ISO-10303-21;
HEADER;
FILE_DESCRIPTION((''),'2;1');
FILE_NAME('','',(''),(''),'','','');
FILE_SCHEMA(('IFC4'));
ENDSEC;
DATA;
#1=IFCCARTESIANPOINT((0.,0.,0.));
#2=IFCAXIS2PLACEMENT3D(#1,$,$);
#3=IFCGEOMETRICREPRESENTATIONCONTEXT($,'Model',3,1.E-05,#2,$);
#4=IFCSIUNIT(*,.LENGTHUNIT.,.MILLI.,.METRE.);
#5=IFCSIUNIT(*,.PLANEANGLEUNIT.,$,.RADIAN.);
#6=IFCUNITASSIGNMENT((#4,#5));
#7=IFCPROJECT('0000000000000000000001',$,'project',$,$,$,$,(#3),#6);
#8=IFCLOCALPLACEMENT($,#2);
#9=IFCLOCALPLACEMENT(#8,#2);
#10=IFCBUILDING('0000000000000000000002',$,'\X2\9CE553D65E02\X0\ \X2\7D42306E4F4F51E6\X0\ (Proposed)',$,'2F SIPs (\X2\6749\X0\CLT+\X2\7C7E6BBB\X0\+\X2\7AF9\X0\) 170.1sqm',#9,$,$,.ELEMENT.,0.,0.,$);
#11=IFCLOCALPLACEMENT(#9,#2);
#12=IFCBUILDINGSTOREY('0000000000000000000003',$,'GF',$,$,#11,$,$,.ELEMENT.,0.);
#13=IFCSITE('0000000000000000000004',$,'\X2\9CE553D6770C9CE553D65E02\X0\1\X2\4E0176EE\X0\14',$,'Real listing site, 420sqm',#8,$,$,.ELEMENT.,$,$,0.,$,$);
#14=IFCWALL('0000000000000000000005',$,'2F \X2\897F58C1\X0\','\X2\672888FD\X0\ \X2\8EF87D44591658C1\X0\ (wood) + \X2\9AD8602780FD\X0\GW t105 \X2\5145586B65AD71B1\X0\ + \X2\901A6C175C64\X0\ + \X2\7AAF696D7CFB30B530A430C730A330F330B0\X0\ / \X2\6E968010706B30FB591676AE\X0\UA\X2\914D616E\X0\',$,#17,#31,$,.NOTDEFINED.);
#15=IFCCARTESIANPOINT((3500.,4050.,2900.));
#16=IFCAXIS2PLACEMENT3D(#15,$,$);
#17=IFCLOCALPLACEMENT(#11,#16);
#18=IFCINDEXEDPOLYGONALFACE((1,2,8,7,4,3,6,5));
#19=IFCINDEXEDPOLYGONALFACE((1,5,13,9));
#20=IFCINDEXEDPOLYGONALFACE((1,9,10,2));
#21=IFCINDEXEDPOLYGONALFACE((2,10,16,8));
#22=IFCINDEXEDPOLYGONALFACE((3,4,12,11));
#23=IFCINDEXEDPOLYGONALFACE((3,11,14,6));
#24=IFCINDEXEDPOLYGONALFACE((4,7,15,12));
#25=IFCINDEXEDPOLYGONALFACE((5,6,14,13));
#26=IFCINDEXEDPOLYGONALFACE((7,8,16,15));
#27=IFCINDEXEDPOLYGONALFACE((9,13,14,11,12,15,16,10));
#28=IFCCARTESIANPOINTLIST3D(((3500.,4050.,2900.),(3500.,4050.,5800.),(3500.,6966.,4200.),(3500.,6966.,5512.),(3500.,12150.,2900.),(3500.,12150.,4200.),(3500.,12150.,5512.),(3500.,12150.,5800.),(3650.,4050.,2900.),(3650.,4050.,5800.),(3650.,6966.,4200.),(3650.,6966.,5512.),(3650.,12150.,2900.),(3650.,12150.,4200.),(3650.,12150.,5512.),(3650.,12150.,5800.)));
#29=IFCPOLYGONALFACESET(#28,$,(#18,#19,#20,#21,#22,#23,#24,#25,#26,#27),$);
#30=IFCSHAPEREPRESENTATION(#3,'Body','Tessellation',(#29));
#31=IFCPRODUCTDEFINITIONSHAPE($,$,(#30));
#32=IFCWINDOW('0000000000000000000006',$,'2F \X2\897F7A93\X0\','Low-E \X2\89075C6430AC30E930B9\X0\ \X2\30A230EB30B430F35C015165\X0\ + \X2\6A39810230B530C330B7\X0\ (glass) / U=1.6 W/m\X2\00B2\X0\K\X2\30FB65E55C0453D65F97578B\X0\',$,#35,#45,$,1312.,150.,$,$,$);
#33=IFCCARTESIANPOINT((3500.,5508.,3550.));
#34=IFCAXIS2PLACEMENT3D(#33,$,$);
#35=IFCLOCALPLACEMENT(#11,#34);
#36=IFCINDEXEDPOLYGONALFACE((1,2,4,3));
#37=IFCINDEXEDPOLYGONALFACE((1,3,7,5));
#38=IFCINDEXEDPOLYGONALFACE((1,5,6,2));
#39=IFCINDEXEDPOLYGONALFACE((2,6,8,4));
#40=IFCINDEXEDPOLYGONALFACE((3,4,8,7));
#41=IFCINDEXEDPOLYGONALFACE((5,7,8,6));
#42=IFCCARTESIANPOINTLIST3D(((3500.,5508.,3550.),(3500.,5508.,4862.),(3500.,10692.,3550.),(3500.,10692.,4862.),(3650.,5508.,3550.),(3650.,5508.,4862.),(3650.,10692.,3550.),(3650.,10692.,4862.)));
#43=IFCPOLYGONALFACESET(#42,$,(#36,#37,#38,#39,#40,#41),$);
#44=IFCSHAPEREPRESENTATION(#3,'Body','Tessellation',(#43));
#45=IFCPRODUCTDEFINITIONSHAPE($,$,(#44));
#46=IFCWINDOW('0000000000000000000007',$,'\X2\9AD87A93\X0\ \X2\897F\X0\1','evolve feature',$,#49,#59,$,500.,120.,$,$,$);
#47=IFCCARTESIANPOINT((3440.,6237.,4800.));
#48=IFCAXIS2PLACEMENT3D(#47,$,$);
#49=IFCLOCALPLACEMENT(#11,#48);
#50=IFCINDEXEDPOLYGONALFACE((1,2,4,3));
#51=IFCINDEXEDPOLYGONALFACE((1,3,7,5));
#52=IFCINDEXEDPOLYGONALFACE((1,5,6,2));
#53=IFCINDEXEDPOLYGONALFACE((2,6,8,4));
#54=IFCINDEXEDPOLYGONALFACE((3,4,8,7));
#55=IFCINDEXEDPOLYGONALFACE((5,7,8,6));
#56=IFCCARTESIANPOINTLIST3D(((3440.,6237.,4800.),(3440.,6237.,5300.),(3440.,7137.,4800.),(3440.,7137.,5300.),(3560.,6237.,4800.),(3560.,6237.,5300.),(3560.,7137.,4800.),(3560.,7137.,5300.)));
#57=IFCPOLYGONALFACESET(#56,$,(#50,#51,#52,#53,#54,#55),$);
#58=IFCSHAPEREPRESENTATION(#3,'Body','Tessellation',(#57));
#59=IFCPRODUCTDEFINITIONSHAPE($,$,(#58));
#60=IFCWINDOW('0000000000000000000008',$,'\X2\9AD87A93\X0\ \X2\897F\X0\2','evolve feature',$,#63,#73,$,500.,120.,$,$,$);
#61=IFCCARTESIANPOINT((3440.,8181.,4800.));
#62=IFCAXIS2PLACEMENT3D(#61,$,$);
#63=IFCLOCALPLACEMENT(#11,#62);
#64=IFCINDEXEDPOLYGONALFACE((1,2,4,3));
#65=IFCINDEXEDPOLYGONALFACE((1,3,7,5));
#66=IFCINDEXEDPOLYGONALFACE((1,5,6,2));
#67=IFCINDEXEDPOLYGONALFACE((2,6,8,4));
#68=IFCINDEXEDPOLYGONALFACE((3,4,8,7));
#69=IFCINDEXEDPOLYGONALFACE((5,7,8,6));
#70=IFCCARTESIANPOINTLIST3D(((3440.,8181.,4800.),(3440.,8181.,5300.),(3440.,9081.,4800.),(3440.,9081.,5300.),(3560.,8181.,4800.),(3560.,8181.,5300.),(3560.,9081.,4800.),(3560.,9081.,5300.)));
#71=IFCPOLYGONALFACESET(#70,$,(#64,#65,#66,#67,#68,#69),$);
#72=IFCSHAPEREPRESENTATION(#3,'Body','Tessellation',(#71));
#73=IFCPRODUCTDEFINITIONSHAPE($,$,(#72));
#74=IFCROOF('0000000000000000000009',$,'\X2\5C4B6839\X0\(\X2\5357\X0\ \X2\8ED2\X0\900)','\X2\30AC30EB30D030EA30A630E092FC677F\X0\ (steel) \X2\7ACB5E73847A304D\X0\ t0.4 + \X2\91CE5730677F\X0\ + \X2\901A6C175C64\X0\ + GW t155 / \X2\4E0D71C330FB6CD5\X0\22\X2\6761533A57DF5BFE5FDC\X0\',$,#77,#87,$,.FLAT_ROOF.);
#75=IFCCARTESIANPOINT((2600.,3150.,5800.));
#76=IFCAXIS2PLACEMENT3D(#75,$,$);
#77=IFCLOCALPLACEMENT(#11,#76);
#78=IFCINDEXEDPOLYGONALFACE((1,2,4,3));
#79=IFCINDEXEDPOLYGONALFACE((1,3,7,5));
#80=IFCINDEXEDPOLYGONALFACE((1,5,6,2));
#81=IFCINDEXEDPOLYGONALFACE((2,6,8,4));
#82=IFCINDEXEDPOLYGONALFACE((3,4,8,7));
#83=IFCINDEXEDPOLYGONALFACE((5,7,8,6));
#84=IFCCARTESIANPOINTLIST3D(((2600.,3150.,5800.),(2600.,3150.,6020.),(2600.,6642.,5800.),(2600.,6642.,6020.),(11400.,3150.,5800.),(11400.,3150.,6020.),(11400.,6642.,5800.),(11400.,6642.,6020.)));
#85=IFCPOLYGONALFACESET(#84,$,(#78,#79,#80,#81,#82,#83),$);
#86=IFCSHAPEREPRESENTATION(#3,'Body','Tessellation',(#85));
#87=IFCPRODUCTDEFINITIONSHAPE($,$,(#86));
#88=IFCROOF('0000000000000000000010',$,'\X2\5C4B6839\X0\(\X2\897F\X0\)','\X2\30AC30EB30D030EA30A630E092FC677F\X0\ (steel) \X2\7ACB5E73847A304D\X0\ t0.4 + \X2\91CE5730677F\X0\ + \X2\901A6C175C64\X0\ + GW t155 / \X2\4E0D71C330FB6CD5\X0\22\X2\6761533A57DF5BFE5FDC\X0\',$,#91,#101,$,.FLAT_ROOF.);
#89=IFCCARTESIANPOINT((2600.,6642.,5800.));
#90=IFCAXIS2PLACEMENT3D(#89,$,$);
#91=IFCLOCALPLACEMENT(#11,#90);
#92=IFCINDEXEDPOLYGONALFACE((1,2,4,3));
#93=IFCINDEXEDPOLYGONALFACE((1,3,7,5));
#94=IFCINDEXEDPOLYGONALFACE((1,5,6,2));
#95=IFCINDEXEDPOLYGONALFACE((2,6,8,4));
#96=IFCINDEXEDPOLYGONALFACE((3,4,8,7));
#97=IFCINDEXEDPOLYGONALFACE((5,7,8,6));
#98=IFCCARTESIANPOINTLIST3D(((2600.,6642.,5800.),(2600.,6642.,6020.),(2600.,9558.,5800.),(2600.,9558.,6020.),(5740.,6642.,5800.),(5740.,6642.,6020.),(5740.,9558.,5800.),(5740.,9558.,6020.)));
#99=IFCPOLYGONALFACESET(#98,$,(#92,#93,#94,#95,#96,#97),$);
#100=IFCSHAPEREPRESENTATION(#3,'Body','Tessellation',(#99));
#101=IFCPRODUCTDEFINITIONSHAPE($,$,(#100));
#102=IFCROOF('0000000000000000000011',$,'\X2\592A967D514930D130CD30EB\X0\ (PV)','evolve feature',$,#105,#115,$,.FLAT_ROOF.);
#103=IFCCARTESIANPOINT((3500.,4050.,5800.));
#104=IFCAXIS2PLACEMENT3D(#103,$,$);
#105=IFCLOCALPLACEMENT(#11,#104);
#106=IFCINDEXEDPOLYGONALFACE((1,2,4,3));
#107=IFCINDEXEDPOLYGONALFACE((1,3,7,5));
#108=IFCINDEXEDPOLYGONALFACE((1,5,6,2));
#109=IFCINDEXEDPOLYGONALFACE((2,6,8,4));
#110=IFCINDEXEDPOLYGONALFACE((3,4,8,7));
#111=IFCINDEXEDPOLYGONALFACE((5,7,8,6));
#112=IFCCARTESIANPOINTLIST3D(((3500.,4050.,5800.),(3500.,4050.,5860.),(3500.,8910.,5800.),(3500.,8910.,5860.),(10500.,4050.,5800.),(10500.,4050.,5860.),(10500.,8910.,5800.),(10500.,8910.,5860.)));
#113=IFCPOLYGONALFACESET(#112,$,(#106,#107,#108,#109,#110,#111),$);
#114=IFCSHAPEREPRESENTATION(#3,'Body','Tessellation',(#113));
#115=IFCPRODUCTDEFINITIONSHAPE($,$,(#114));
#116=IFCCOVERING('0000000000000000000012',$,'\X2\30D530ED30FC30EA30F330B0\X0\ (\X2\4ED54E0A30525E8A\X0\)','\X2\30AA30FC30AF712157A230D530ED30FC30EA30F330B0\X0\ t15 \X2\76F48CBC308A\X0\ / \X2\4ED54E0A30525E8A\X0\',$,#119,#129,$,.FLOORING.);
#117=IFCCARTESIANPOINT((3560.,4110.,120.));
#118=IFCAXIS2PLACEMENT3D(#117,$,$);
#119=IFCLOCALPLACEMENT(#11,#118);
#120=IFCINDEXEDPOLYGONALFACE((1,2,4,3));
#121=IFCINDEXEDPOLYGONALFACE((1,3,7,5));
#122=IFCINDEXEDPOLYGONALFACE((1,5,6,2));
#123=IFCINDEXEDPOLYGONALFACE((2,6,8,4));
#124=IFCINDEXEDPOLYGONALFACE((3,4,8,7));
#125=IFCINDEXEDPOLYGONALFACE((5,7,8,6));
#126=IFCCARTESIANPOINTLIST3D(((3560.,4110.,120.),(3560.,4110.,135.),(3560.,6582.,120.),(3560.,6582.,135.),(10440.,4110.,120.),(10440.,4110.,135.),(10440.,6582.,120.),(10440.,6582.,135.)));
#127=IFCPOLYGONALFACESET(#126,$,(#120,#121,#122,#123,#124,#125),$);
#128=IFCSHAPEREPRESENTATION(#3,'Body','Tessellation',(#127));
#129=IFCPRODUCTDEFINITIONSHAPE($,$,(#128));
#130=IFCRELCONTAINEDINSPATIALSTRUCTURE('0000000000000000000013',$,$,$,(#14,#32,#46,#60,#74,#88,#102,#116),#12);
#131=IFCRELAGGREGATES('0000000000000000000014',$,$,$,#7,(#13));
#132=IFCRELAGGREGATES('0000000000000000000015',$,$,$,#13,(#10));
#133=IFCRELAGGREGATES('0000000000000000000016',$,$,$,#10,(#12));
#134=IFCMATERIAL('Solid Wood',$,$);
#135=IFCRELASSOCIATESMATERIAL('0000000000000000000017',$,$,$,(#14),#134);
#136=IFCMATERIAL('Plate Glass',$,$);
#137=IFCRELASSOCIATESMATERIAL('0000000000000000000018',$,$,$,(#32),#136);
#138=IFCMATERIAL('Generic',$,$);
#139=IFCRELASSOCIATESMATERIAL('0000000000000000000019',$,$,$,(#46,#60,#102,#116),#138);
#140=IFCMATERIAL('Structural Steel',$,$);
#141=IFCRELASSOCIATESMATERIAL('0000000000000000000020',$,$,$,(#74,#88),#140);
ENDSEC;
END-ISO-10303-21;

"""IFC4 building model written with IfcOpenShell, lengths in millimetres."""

from ifc_helpers import new_model, si_unit, frame, frame_2d, origin, place, context, project, spatial, rectangle, extrude, material, element, fill, save


model = new_model("IFC4")

# Units and contexts
model_context = context("Model", 3, precision=1e-05, world=origin())
ifc_project = project(units=[si_unit("LENGTHUNIT", "METRE", prefix="MILLI"), si_unit("PLANEANGLEUNIT", "RADIAN")], contexts=[model_context])

# Site, building, storey
site_placement = place(None, origin())
site = spatial("IfcSite", under=ifc_project, at=site_placement, Name="鳥取県鳥取市1丁目14", ObjectType="Real listing site, 420sqm", CompositionType="ELEMENT", RefElevation=0.0)
building_placement = place(site_placement, origin())
building = spatial("IfcBuilding", under=site, at=building_placement, Name="鳥取市 終の住処 (Proposed)", ObjectType="2F SIPs (杉CLT+籾殻+竹) 170.1sqm", CompositionType="ELEMENT", ElevationOfRefHeight=0.0, ElevationOfTerrain=0.0)
storey_placement = place(building_placement, origin())
storey = spatial("IfcBuildingStorey", under=building, at=storey_placement, Name="GF", CompositionType="ELEMENT", Elevation=0.0)

# Shared definitions
ifc_material_1 = material(Name="Solid Wood")
ifc_material_2 = material(Name="Generic")

# Shared definitions
ifc_material_3 = material(Name="Plate Glass")

# Wall, openings, windows
wall_1_placement = place(storey_placement, frame((3500.0, 4050.0, 2900.0)))
wall_1 = element("IfcWall", 1, at=wall_1_placement, inside=storey, material=ifc_material_1, Name="2F 西壁", Description="木製 軸組外壁 (wood) + 高性能GW t105 充填断熱 + 通気層 + 窯業系サイディング / 準耐火・外皮UA配慮", PredefinedType="NOTDEFINED", context=model_context, shape_type="SweptSolid", body=[
    extrude(rectangle(XDim=150.0, YDim=8100.0, at=frame_2d((75.0, 4050.0))), frame((3500.0, 4050.0, 2900.0)), (0.0, 0.0, 1.0), 2900.0),
])
opening_1_placement = place(storey_placement, frame((3500.0, 5508.0, 3550.0)))
opening_1 = element("IfcOpeningElement", 2, at=opening_1_placement, cuts=wall_1, PredefinedType="NOTDEFINED", context=model_context, shape_type="SweptSolid", body=[
    extrude(rectangle(XDim=150.0, YDim=5184.0, at=frame_2d((75.0, 2592.0))), frame((3500.0, 5508.0, 3550.0)), (0.0, 0.0, 1.0), 1312.0),
])
opening_2_placement = place(storey_placement, frame((3440.0, 6237.0, 4800.0)))
opening_2 = element("IfcOpeningElement", 3, at=opening_2_placement, cuts=wall_1, PredefinedType="NOTDEFINED", context=model_context, shape_type="SweptSolid", body=[
    extrude(rectangle(XDim=120.0, YDim=900.0, at=frame_2d((60.0, 450.0))), frame((3440.0, 6237.0, 4800.0)), (0.0, 0.0, 1.0), 500.0),
])
opening_3_placement = place(storey_placement, frame((3440.0, 8181.0, 4800.0)))
opening_3 = element("IfcOpeningElement", 4, at=opening_3_placement, cuts=wall_1, PredefinedType="NOTDEFINED", context=model_context, shape_type="SweptSolid", body=[
    extrude(rectangle(XDim=120.0, YDim=900.0, at=frame_2d((60.0, 450.0))), frame((3440.0, 8181.0, 4800.0)), (0.0, 0.0, 1.0), 500.0),
])
window_1_placement = place(storey_placement, frame((3500.0, 5508.0, 3550.0)))
window_1 = element("IfcWindow", 5, at=window_1_placement, inside=storey, material=ifc_material_3, Name="2F 西窓", Description="Low-E 複層ガラス アルゴン封入 + 樹脂サッシ (glass) / U=1.6 W/m²K・日射取得型", OverallHeight=1312.0, OverallWidth=150.0, context=model_context, shape_type="SweptSolid", body=[
    extrude(rectangle(XDim=150.0, YDim=5184.0, at=frame_2d((75.0, 2592.0))), frame((3500.0, 5508.0, 3550.0)), (0.0, 0.0, 1.0), 1312.0),
])
fill(opening_1, window_1)
window_2_placement = place(storey_placement, frame((3440.0, 6237.0, 4800.0)))
window_2 = element("IfcWindow", 6, at=window_2_placement, inside=storey, material=ifc_material_2, Name="高窓 西1", Description="evolve feature", OverallHeight=500.0, OverallWidth=120.0, context=model_context, shape_type="SweptSolid", body=[
    extrude(rectangle(XDim=120.0, YDim=900.0, at=frame_2d((60.0, 450.0))), frame((3440.0, 6237.0, 4800.0)), (0.0, 0.0, 1.0), 500.0),
])
fill(opening_2, window_2)
window_3_placement = place(storey_placement, frame((3440.0, 8181.0, 4800.0)))
window_3 = element("IfcWindow", 7, at=window_3_placement, inside=storey, material=ifc_material_2, Name="高窓 西2", Description="evolve feature", OverallHeight=500.0, OverallWidth=120.0, context=model_context, shape_type="SweptSolid", body=[
    extrude(rectangle(XDim=120.0, YDim=900.0, at=frame_2d((60.0, 450.0))), frame((3440.0, 8181.0, 4800.0)), (0.0, 0.0, 1.0), 500.0),
])
fill(opening_3, window_3)

# Roofs
ifc_material_4 = material(Name="Structural Steel")
roof_1_placement = place(storey_placement, frame((2600.0, 3150.0, 5800.0)))
element("IfcRoof", 8, at=roof_1_placement, inside=storey, material=ifc_material_4, Name="屋根(南 軒900)", Description="ガルバリウム鋼板 (steel) 立平葺き t0.4 + 野地板 + 通気層 + GW t155 / 不燃・法22条区域対応", PredefinedType="FLAT_ROOF", context=model_context, shape_type="SweptSolid", body=[
    extrude(rectangle(XDim=8800.0, YDim=3492.0, at=frame_2d((4400.0, 1746.0))), frame((2600.0, 3150.0, 5800.0)), (0.0, 0.0, 1.0), 220.0),
])
roof_2_placement = place(storey_placement, frame((2600.0, 6642.0, 5800.0)))
element("IfcRoof", 9, at=roof_2_placement, inside=storey, material=ifc_material_4, Name="屋根(西)", Description="ガルバリウム鋼板 (steel) 立平葺き t0.4 + 野地板 + 通気層 + GW t155 / 不燃・法22条区域対応", PredefinedType="FLAT_ROOF", context=model_context, shape_type="SweptSolid", body=[
    extrude(rectangle(XDim=3140.0, YDim=2916.0, at=frame_2d((1570.0, 1458.0))), frame((2600.0, 6642.0, 5800.0)), (0.0, 0.0, 1.0), 220.0),
])
roof_3_placement = place(storey_placement, frame((3500.0, 4050.0, 5800.0)))
element("IfcRoof", 10, at=roof_3_placement, inside=storey, material=ifc_material_2, Name="太陽光パネル (PV)", Description="evolve feature", PredefinedType="FLAT_ROOF", context=model_context, shape_type="SweptSolid", body=[
    extrude(rectangle(XDim=7000.0, YDim=4860.0, at=frame_2d((3500.0, 2430.0))), frame((3500.0, 4050.0, 5800.0)), (0.0, 0.0, 1.0), 60.0),
])

# Covering
covering_placement = place(storey_placement, frame((3560.0, 4110.0, 120.0)))
element("IfcCovering", 11, at=covering_placement, inside=storey, material=ifc_material_2, Name="フローリング (仕上げ床)", Description="オーク無垢フローリング t15 直貼り / 仕上げ床", PredefinedType="FLOORING", context=model_context, shape_type="SweptSolid", body=[
    extrude(rectangle(XDim=6880.0, YDim=2472.0, at=frame_2d((3440.0, 1236.0))), frame((3560.0, 4110.0, 120.0)), (0.0, 0.0, 1.0), 15.0),
])

save(model, "model.ifc")
